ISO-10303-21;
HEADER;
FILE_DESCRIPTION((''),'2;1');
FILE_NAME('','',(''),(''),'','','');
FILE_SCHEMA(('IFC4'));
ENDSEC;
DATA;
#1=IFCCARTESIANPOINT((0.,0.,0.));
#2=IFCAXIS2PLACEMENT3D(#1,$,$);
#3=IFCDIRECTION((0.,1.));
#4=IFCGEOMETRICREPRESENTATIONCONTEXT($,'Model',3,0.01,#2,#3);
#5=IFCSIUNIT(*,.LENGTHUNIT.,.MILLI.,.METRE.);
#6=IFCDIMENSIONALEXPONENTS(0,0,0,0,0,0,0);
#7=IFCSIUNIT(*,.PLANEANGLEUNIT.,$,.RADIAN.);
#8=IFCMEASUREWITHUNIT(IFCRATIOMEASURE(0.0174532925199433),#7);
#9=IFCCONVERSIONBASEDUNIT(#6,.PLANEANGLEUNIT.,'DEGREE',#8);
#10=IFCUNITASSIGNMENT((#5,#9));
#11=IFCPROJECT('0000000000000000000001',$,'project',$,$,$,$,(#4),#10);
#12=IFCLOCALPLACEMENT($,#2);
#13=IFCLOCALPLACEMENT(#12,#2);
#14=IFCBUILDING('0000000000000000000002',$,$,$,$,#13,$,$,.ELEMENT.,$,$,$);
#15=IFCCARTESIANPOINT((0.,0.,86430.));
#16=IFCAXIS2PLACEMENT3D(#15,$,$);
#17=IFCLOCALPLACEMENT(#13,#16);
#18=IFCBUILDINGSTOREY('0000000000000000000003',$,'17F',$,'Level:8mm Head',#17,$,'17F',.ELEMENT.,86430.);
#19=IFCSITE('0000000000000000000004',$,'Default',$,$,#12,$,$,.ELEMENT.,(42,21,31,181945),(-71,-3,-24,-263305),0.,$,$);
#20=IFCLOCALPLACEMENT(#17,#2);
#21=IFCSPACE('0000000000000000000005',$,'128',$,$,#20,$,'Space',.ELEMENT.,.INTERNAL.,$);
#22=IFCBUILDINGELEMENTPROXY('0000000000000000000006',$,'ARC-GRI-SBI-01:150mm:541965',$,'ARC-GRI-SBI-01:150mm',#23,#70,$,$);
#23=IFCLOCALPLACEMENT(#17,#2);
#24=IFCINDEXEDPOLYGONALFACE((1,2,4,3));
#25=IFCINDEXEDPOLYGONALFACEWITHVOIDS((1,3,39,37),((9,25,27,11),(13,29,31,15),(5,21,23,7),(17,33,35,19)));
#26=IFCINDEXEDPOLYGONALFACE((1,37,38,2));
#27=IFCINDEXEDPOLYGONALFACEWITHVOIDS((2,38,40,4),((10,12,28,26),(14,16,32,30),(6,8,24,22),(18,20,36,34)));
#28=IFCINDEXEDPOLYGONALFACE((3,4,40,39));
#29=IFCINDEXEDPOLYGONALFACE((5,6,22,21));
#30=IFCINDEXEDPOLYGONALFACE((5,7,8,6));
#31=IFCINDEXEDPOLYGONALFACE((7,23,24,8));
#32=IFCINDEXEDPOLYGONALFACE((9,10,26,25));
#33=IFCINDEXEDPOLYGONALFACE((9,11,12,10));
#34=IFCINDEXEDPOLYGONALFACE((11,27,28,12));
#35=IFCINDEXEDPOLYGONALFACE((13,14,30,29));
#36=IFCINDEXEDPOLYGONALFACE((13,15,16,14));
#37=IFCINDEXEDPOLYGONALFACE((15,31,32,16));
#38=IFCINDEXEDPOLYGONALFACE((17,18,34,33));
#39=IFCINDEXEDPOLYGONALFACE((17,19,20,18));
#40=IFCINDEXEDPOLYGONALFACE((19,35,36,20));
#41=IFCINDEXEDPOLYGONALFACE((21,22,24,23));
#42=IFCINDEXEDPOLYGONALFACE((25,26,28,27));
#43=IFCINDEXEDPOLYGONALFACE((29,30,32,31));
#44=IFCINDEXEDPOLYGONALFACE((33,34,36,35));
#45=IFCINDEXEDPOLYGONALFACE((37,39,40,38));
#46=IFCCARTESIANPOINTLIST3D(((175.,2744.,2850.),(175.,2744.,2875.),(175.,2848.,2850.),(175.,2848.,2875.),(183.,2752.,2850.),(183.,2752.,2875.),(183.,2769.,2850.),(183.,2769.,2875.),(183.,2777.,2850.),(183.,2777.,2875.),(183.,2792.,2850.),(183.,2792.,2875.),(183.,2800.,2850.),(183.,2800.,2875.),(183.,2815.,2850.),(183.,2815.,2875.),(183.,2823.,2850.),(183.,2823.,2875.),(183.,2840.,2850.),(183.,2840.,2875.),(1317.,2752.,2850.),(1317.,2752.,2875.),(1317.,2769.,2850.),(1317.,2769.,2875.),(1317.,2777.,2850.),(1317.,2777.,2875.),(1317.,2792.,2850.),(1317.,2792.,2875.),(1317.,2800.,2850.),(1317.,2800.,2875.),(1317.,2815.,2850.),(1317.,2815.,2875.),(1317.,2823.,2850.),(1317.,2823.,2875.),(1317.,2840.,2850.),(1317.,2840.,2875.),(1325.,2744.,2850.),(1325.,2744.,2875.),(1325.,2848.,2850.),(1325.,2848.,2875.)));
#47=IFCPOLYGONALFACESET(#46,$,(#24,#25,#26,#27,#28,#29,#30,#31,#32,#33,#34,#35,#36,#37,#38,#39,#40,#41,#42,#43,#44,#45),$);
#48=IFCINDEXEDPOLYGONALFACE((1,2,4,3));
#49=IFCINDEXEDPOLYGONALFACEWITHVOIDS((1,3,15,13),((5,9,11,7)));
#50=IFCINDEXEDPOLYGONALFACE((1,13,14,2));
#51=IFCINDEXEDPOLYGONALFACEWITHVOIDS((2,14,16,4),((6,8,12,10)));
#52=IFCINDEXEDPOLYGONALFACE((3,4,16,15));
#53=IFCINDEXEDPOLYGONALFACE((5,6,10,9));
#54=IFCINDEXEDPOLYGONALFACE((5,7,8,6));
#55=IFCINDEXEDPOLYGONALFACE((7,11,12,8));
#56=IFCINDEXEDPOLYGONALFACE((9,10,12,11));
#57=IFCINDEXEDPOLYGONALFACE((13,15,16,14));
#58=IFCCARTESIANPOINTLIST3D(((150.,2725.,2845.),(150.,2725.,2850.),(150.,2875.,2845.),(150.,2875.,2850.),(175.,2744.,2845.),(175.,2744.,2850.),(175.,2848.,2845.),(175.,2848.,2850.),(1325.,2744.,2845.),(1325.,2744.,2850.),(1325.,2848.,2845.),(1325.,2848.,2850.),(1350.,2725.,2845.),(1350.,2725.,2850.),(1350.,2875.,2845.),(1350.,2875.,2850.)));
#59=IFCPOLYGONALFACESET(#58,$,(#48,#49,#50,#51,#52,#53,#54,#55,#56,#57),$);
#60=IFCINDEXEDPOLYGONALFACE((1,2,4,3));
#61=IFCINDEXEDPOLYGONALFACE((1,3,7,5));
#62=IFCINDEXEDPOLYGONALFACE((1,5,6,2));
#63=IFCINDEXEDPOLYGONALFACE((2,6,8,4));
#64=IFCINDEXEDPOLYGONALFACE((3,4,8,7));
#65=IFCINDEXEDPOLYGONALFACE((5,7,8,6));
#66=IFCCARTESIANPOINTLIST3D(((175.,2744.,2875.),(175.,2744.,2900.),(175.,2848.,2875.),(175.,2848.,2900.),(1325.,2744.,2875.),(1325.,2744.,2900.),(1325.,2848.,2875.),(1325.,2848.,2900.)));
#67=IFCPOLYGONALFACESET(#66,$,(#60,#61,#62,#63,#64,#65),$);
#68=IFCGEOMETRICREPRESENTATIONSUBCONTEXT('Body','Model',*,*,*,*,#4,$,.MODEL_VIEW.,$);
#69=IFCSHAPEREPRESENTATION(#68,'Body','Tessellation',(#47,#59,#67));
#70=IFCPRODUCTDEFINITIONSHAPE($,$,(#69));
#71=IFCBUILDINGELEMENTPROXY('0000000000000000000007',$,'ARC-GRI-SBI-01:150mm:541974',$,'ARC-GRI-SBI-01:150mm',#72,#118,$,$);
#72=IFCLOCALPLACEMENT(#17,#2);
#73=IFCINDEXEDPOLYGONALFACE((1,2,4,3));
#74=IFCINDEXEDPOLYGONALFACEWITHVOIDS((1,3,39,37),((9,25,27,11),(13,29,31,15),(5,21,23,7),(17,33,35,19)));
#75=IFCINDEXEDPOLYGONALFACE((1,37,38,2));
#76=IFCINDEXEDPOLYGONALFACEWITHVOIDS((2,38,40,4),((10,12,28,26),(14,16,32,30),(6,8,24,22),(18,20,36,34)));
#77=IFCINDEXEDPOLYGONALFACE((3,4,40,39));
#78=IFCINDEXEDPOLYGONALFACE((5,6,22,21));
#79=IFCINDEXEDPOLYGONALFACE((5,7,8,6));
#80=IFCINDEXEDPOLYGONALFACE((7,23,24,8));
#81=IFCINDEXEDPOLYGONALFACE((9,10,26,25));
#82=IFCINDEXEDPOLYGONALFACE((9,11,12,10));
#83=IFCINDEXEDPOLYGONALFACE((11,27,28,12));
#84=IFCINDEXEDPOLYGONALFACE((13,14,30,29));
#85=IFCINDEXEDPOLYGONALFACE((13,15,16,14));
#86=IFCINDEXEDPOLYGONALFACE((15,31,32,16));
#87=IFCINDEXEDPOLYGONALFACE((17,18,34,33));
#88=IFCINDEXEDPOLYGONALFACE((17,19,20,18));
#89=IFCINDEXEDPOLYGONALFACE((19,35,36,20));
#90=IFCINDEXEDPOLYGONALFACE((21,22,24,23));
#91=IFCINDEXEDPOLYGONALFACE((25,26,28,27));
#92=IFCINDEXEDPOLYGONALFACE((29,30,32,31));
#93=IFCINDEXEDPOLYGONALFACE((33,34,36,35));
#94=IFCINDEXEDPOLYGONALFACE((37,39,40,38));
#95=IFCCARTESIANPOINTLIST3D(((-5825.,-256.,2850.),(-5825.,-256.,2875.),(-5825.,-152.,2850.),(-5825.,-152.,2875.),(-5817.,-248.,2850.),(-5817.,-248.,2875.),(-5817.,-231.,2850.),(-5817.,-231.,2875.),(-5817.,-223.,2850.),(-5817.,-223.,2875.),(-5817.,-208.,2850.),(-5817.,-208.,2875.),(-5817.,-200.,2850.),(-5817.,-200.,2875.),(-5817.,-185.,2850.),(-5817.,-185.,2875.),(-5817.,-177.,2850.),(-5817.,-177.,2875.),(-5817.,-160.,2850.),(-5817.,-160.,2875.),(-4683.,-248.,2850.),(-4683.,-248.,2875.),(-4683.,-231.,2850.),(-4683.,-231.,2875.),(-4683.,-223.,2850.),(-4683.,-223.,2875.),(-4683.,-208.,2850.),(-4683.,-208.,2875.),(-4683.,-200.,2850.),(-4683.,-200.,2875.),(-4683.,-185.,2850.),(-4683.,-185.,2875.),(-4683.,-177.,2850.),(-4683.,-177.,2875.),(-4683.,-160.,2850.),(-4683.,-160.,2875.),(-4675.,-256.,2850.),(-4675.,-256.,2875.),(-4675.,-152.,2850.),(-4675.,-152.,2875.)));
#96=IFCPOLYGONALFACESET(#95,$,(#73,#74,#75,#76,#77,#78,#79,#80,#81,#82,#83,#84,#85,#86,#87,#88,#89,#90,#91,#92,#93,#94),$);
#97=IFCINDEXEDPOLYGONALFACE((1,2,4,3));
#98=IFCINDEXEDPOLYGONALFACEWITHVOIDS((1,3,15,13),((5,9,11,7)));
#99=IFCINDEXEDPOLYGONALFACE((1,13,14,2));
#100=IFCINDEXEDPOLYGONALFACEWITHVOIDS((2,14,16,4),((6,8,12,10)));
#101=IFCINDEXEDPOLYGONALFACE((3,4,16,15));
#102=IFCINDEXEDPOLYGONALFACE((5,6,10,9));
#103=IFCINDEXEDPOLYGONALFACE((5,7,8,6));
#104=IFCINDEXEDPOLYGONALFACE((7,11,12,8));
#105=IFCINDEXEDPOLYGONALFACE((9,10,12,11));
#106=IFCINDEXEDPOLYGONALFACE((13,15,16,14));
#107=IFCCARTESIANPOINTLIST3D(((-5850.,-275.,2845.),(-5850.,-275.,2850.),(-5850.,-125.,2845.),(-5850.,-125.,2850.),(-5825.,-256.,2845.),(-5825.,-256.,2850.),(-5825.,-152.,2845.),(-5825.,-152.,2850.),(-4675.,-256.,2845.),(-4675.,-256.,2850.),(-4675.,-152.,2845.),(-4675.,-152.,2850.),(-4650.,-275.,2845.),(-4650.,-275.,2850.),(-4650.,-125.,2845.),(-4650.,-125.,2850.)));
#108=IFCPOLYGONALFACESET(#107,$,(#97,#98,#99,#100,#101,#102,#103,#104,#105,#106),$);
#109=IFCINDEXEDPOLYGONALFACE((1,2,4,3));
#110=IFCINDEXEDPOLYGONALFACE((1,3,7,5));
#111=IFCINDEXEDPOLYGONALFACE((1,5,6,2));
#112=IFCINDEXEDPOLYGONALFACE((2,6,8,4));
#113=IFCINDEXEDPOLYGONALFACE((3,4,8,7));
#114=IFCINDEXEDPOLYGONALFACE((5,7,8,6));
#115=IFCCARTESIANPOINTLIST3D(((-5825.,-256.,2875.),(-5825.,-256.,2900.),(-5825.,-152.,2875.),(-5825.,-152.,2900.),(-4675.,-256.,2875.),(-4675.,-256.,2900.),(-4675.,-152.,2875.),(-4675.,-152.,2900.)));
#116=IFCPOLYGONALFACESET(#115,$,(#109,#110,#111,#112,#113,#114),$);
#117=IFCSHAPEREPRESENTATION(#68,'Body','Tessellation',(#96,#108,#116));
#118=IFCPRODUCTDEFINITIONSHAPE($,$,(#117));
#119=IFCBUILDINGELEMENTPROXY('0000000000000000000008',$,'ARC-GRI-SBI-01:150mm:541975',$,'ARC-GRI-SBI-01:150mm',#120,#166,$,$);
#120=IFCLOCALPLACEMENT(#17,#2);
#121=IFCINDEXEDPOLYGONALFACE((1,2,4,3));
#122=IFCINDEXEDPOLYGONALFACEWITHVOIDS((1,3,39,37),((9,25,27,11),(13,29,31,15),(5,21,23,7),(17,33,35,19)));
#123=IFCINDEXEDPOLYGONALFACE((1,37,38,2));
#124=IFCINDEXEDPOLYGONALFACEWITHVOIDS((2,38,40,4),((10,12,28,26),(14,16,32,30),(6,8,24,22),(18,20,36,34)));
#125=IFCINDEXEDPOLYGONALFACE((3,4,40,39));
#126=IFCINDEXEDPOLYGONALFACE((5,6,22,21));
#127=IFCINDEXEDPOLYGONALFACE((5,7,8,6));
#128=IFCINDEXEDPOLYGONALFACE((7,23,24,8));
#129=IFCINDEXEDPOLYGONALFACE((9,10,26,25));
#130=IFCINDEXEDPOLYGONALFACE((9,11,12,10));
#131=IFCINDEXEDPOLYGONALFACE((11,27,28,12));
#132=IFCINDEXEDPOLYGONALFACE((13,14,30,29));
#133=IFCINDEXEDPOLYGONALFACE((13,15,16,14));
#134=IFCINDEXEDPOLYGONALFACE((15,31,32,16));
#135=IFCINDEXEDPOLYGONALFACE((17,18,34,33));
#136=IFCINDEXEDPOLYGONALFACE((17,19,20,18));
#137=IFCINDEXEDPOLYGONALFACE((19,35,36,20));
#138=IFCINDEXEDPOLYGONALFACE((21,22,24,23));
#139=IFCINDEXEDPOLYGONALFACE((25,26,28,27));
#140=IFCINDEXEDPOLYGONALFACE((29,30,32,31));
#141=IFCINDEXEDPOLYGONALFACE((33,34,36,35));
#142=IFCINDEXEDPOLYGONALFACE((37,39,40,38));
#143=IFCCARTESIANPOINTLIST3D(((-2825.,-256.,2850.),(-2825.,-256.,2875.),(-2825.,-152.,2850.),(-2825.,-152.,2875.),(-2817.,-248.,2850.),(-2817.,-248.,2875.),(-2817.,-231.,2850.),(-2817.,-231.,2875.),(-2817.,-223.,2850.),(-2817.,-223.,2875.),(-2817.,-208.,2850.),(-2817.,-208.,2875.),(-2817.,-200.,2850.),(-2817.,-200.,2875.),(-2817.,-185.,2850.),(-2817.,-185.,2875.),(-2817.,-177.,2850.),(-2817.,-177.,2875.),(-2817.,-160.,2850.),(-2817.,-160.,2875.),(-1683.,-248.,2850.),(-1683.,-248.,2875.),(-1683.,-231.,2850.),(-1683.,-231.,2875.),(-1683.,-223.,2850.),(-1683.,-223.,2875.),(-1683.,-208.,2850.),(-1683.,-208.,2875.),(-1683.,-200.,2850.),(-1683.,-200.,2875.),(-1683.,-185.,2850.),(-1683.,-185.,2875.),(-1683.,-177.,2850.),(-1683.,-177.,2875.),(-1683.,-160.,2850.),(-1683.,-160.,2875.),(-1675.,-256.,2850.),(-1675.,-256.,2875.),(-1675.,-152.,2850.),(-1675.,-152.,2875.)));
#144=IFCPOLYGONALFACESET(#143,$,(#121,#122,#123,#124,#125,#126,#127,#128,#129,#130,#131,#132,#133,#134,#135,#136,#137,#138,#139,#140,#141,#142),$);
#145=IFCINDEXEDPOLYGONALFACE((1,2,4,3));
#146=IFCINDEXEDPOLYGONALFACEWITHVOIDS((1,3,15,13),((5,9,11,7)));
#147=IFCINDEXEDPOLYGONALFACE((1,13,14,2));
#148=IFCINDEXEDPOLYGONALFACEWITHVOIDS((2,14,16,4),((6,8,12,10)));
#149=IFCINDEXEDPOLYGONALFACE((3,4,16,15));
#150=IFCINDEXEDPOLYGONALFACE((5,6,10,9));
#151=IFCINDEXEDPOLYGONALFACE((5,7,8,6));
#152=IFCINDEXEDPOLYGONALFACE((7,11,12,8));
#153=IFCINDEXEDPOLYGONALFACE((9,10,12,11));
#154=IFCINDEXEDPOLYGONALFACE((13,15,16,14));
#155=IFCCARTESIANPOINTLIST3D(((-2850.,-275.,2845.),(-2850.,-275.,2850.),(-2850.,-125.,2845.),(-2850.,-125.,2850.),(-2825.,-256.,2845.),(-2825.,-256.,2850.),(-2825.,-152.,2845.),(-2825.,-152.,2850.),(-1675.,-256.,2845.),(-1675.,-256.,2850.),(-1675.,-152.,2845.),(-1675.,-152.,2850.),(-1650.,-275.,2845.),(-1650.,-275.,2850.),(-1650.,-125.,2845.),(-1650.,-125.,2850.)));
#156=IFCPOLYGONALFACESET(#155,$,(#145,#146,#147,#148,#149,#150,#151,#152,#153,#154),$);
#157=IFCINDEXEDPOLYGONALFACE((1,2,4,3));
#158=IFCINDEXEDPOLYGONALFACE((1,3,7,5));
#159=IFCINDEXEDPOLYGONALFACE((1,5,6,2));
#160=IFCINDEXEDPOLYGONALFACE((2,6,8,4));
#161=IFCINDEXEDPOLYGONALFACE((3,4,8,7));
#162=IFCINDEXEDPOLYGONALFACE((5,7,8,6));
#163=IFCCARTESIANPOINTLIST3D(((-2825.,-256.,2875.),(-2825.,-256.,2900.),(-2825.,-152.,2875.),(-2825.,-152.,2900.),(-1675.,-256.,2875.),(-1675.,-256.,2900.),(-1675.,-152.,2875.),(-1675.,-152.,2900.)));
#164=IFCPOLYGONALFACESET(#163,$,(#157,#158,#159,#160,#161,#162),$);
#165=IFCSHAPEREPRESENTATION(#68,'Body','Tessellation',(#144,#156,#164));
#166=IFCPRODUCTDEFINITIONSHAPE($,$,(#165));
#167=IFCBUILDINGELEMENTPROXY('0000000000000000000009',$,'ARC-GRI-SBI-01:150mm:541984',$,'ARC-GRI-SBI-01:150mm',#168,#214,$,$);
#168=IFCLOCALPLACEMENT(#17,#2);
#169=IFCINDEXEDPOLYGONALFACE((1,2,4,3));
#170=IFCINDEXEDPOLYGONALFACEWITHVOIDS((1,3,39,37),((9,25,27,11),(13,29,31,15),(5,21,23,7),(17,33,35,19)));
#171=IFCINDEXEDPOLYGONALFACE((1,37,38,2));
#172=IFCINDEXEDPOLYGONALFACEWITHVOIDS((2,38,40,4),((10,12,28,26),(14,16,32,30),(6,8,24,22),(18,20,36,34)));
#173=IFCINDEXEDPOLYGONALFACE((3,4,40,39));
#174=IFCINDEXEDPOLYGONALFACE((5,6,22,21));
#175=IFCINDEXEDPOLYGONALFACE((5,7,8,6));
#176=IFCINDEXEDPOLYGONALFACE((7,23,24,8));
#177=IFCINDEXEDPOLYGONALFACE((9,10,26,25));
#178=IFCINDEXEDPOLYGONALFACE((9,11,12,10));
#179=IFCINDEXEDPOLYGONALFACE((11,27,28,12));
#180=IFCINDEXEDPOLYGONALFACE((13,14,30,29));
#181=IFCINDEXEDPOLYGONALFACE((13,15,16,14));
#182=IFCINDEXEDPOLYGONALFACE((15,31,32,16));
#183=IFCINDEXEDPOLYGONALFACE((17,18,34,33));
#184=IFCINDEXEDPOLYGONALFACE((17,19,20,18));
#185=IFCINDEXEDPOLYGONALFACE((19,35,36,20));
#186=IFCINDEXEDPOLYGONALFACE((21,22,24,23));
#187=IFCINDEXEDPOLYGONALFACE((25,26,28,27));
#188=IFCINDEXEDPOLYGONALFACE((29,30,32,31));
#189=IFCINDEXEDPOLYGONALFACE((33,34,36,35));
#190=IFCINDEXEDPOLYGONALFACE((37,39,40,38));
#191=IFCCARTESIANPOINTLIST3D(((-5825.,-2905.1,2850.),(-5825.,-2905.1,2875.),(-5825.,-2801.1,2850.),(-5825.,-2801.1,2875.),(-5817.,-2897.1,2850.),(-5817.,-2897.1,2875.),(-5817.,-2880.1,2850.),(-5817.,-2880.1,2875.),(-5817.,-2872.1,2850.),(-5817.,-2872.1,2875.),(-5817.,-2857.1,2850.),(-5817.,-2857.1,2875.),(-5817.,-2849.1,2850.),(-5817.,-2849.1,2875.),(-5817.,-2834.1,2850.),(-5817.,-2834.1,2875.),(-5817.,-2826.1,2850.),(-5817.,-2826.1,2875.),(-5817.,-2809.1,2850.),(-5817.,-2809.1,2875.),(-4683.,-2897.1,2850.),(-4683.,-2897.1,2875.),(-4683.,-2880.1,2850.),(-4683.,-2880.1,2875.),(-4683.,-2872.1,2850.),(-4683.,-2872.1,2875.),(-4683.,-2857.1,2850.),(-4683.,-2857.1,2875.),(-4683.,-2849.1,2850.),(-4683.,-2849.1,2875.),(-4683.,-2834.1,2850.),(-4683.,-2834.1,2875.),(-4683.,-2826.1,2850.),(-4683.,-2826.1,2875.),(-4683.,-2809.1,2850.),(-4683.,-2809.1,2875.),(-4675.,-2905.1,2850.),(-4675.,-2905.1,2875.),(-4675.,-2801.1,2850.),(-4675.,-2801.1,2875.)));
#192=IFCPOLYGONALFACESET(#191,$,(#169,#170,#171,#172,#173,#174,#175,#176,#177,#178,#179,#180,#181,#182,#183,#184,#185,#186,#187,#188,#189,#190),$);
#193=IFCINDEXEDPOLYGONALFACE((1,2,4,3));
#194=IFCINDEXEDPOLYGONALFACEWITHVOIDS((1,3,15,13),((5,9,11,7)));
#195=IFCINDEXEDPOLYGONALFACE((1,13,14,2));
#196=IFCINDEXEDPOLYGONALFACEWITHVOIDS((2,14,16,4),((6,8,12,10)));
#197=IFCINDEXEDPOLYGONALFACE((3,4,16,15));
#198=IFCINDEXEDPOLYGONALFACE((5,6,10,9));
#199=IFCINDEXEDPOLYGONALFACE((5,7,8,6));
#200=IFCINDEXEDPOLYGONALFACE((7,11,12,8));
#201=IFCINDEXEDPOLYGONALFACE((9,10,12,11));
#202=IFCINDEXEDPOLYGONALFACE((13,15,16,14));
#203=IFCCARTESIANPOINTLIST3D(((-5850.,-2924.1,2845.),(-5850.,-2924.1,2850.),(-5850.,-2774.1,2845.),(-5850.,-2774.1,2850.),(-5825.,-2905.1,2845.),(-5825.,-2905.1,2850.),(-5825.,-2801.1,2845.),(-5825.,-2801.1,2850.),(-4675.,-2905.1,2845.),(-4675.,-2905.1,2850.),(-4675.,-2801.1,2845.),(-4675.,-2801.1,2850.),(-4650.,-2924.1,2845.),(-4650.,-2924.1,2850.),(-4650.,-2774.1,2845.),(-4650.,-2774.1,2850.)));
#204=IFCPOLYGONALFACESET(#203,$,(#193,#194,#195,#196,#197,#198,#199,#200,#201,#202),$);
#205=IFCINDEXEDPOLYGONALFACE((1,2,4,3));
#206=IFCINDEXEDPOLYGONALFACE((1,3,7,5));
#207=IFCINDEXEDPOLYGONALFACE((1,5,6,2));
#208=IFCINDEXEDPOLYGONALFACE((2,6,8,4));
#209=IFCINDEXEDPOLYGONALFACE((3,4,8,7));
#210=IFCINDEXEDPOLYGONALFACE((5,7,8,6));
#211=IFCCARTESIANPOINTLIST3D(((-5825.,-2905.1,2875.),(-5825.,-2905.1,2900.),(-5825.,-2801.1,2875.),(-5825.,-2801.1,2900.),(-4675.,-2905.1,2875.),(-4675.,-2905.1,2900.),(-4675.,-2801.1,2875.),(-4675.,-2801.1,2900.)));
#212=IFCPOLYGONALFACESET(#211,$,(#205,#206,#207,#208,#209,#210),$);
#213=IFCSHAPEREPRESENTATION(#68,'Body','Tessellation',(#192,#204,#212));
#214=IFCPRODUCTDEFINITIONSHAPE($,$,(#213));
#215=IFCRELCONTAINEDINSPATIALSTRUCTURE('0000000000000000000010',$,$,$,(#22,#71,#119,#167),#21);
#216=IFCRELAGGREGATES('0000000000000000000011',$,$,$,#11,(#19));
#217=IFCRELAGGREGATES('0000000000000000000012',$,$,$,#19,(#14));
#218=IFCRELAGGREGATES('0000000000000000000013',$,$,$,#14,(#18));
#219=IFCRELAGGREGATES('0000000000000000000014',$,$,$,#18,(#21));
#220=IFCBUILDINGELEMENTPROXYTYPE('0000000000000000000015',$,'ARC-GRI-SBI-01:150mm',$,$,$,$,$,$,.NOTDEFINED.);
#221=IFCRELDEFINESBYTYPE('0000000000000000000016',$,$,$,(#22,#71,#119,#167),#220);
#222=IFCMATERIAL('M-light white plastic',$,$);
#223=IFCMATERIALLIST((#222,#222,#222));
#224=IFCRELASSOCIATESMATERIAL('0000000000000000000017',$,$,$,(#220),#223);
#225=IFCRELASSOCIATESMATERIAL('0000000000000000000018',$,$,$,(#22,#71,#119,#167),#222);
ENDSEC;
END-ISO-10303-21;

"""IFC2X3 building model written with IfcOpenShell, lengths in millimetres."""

from ifc_helpers import new_model, entity, si_unit, converted_unit, direction, frame, origin, origin_2d_with_axis, place, context, subcontext, project, spatial, polyline, rectangle, outline, extrude, source, transform, mapped, material, material_list, type_object, type_shapes, element, save


model = new_model("IFC2X3")

# Units and contexts
model_context = context("Model", 3, precision=0.01, world=origin(), true_north=direction((0.0, 1.0)))
body_context = subcontext(model_context, "Body", "Model", "MODEL_VIEW")
ifc_project = project(units=[si_unit("LENGTHUNIT", "METRE", prefix="MILLI"), converted_unit("PLANEANGLEUNIT", "DEGREE", entity("IfcRatioMeasure", 0.0174532925199433), si_unit("PLANEANGLEUNIT", "RADIAN"), dimensions=[0, 0, 0, 0, 0, 0, 0])], contexts=[model_context])

# Site, building, storey
site_placement = place(None, origin())
site = spatial("IfcSite", under=ifc_project, at=site_placement, Name="Default", CompositionType="ELEMENT", RefLatitude=(42, 21, 31, 181945), RefLongitude=(-71, -3, -24, -263305), RefElevation=0.0)
building_placement = place(site_placement, origin())
building = spatial("IfcBuilding", under=site, at=building_placement, CompositionType="ELEMENT")
storey_placement = place(building_placement, frame((0.0, 0.0, 86430.0)))
storey = spatial("IfcBuildingStorey", under=building, at=storey_placement, Name="17F", ObjectType="Level:8mm Head", LongName="17F", CompositionType="ELEMENT", Elevation=86430.0)

# Shared definitions
space_placement = place(storey_placement, origin())
space = spatial("IfcSpace", under=storey, at=space_placement, Name="128", LongName="Space", CompositionType="ELEMENT", InteriorOrExteriorSpace="INTERNAL")

# Building element proxies
ifc_material_1 = material(Name="M-light white plastic")
ifc_material_list = material_list([ifc_material_1, ifc_material_1, ifc_material_1])
building_element_proxy_type = type_object("IfcBuildingElementProxyType", Name="ARC-GRI-SBI-01:150mm", PredefinedType="NOTDEFINED", material=ifc_material_list)
shared_shape = source(origin(), body_context, "Body", "SweptSolid", [
    extrude(outline(polyline([(-575.0, -52.0), (575.0, -52.0), (575.0, 52.0), (-575.0, 52.0), (-575.0, -52.0)]), holes=[polyline([(-567.0, -44.0), (-567.0, -27.0), (567.0, -27.0), (567.0, -44.0), (-567.0, -44.0)]), polyline([(567.0, -4.0), (567.0, -19.0), (-567.0, -19.0), (-567.0, -4.0), (567.0, -4.0)]), polyline([(-567.0, 44.0), (567.0, 44.0), (567.0, 27.0), (-567.0, 27.0), (-567.0, 44.0)]), polyline([(567.0, 4.0), (-567.0, 4.0), (-567.0, 19.0), (567.0, 19.0), (567.0, 4.0)])]), frame((425.0, 4.0, 4000.0), z_axis=(0.0, 0.0, 1.0), x_axis=(-1.0, 0.0, 0.0)), (0.0, 0.0, 1.0), 25.0),
    extrude(outline(polyline([(-600.0, -75.0), (600.0, -75.0), (600.0, 75.0), (-600.0, 75.0), (-600.0, -75.0)]), holes=[polyline([(-575.0, -56.0), (-575.0, 48.0), (575.0, 48.0), (575.0, -56.0), (-575.0, -56.0)])]), frame((425.0, 0.0, 3995.0), z_axis=(0.0, 0.0, 1.0), x_axis=(-1.0, 0.0, 0.0)), (0.0, 0.0, 1.0), 5.0),
    extrude(rectangle(XDim=1150.0, YDim=104.0, at=origin_2d_with_axis()), frame((425.0, 4.0, 4025.0), z_axis=(0.0, 0.0, 1.0), x_axis=(-1.0, 0.0, 0.0)), (0.0, 0.0, 1.0), 25.0),
])
type_shapes(building_element_proxy_type, [shared_shape])
for number, where, z_axis, x_axis, name in (
    (1, (1175.0, 2800.0, -1150.0), (0.0, 0.0, 1.0), (-1.0, 0.0, 0.0), "ARC-GRI-SBI-01:150mm:541965"),
    (2, (-4825.0, -200.0, -1150.0), (0.0, 0.0, 1.0), (-1.0, 0.0, 0.0), "ARC-GRI-SBI-01:150mm:541974"),
    (3, (-1825.0, -200.0, -1150.0), (0.0, 0.0, 1.0), (-1.0, 0.0, 0.0), "ARC-GRI-SBI-01:150mm:541975"),
    (4, (-4825.0, -2849.1, -1150.0), (0.0, 0.0, 1.0), (-1.0, 0.0, 0.0), "ARC-GRI-SBI-01:150mm:541984"),
):
    element("IfcBuildingElementProxy", number, at=place(space_placement, frame(where, z_axis=z_axis, x_axis=x_axis)), inside=space, type_object=building_element_proxy_type, material=ifc_material_1, Name=name, ObjectType="ARC-GRI-SBI-01:150mm", context=body_context, shape_type="MappedRepresentation", body=[
        mapped(shared_shape, transform((0.0, 0.0, 0.0), scale=1.0)),
    ])

save(model, "model.ifc")
